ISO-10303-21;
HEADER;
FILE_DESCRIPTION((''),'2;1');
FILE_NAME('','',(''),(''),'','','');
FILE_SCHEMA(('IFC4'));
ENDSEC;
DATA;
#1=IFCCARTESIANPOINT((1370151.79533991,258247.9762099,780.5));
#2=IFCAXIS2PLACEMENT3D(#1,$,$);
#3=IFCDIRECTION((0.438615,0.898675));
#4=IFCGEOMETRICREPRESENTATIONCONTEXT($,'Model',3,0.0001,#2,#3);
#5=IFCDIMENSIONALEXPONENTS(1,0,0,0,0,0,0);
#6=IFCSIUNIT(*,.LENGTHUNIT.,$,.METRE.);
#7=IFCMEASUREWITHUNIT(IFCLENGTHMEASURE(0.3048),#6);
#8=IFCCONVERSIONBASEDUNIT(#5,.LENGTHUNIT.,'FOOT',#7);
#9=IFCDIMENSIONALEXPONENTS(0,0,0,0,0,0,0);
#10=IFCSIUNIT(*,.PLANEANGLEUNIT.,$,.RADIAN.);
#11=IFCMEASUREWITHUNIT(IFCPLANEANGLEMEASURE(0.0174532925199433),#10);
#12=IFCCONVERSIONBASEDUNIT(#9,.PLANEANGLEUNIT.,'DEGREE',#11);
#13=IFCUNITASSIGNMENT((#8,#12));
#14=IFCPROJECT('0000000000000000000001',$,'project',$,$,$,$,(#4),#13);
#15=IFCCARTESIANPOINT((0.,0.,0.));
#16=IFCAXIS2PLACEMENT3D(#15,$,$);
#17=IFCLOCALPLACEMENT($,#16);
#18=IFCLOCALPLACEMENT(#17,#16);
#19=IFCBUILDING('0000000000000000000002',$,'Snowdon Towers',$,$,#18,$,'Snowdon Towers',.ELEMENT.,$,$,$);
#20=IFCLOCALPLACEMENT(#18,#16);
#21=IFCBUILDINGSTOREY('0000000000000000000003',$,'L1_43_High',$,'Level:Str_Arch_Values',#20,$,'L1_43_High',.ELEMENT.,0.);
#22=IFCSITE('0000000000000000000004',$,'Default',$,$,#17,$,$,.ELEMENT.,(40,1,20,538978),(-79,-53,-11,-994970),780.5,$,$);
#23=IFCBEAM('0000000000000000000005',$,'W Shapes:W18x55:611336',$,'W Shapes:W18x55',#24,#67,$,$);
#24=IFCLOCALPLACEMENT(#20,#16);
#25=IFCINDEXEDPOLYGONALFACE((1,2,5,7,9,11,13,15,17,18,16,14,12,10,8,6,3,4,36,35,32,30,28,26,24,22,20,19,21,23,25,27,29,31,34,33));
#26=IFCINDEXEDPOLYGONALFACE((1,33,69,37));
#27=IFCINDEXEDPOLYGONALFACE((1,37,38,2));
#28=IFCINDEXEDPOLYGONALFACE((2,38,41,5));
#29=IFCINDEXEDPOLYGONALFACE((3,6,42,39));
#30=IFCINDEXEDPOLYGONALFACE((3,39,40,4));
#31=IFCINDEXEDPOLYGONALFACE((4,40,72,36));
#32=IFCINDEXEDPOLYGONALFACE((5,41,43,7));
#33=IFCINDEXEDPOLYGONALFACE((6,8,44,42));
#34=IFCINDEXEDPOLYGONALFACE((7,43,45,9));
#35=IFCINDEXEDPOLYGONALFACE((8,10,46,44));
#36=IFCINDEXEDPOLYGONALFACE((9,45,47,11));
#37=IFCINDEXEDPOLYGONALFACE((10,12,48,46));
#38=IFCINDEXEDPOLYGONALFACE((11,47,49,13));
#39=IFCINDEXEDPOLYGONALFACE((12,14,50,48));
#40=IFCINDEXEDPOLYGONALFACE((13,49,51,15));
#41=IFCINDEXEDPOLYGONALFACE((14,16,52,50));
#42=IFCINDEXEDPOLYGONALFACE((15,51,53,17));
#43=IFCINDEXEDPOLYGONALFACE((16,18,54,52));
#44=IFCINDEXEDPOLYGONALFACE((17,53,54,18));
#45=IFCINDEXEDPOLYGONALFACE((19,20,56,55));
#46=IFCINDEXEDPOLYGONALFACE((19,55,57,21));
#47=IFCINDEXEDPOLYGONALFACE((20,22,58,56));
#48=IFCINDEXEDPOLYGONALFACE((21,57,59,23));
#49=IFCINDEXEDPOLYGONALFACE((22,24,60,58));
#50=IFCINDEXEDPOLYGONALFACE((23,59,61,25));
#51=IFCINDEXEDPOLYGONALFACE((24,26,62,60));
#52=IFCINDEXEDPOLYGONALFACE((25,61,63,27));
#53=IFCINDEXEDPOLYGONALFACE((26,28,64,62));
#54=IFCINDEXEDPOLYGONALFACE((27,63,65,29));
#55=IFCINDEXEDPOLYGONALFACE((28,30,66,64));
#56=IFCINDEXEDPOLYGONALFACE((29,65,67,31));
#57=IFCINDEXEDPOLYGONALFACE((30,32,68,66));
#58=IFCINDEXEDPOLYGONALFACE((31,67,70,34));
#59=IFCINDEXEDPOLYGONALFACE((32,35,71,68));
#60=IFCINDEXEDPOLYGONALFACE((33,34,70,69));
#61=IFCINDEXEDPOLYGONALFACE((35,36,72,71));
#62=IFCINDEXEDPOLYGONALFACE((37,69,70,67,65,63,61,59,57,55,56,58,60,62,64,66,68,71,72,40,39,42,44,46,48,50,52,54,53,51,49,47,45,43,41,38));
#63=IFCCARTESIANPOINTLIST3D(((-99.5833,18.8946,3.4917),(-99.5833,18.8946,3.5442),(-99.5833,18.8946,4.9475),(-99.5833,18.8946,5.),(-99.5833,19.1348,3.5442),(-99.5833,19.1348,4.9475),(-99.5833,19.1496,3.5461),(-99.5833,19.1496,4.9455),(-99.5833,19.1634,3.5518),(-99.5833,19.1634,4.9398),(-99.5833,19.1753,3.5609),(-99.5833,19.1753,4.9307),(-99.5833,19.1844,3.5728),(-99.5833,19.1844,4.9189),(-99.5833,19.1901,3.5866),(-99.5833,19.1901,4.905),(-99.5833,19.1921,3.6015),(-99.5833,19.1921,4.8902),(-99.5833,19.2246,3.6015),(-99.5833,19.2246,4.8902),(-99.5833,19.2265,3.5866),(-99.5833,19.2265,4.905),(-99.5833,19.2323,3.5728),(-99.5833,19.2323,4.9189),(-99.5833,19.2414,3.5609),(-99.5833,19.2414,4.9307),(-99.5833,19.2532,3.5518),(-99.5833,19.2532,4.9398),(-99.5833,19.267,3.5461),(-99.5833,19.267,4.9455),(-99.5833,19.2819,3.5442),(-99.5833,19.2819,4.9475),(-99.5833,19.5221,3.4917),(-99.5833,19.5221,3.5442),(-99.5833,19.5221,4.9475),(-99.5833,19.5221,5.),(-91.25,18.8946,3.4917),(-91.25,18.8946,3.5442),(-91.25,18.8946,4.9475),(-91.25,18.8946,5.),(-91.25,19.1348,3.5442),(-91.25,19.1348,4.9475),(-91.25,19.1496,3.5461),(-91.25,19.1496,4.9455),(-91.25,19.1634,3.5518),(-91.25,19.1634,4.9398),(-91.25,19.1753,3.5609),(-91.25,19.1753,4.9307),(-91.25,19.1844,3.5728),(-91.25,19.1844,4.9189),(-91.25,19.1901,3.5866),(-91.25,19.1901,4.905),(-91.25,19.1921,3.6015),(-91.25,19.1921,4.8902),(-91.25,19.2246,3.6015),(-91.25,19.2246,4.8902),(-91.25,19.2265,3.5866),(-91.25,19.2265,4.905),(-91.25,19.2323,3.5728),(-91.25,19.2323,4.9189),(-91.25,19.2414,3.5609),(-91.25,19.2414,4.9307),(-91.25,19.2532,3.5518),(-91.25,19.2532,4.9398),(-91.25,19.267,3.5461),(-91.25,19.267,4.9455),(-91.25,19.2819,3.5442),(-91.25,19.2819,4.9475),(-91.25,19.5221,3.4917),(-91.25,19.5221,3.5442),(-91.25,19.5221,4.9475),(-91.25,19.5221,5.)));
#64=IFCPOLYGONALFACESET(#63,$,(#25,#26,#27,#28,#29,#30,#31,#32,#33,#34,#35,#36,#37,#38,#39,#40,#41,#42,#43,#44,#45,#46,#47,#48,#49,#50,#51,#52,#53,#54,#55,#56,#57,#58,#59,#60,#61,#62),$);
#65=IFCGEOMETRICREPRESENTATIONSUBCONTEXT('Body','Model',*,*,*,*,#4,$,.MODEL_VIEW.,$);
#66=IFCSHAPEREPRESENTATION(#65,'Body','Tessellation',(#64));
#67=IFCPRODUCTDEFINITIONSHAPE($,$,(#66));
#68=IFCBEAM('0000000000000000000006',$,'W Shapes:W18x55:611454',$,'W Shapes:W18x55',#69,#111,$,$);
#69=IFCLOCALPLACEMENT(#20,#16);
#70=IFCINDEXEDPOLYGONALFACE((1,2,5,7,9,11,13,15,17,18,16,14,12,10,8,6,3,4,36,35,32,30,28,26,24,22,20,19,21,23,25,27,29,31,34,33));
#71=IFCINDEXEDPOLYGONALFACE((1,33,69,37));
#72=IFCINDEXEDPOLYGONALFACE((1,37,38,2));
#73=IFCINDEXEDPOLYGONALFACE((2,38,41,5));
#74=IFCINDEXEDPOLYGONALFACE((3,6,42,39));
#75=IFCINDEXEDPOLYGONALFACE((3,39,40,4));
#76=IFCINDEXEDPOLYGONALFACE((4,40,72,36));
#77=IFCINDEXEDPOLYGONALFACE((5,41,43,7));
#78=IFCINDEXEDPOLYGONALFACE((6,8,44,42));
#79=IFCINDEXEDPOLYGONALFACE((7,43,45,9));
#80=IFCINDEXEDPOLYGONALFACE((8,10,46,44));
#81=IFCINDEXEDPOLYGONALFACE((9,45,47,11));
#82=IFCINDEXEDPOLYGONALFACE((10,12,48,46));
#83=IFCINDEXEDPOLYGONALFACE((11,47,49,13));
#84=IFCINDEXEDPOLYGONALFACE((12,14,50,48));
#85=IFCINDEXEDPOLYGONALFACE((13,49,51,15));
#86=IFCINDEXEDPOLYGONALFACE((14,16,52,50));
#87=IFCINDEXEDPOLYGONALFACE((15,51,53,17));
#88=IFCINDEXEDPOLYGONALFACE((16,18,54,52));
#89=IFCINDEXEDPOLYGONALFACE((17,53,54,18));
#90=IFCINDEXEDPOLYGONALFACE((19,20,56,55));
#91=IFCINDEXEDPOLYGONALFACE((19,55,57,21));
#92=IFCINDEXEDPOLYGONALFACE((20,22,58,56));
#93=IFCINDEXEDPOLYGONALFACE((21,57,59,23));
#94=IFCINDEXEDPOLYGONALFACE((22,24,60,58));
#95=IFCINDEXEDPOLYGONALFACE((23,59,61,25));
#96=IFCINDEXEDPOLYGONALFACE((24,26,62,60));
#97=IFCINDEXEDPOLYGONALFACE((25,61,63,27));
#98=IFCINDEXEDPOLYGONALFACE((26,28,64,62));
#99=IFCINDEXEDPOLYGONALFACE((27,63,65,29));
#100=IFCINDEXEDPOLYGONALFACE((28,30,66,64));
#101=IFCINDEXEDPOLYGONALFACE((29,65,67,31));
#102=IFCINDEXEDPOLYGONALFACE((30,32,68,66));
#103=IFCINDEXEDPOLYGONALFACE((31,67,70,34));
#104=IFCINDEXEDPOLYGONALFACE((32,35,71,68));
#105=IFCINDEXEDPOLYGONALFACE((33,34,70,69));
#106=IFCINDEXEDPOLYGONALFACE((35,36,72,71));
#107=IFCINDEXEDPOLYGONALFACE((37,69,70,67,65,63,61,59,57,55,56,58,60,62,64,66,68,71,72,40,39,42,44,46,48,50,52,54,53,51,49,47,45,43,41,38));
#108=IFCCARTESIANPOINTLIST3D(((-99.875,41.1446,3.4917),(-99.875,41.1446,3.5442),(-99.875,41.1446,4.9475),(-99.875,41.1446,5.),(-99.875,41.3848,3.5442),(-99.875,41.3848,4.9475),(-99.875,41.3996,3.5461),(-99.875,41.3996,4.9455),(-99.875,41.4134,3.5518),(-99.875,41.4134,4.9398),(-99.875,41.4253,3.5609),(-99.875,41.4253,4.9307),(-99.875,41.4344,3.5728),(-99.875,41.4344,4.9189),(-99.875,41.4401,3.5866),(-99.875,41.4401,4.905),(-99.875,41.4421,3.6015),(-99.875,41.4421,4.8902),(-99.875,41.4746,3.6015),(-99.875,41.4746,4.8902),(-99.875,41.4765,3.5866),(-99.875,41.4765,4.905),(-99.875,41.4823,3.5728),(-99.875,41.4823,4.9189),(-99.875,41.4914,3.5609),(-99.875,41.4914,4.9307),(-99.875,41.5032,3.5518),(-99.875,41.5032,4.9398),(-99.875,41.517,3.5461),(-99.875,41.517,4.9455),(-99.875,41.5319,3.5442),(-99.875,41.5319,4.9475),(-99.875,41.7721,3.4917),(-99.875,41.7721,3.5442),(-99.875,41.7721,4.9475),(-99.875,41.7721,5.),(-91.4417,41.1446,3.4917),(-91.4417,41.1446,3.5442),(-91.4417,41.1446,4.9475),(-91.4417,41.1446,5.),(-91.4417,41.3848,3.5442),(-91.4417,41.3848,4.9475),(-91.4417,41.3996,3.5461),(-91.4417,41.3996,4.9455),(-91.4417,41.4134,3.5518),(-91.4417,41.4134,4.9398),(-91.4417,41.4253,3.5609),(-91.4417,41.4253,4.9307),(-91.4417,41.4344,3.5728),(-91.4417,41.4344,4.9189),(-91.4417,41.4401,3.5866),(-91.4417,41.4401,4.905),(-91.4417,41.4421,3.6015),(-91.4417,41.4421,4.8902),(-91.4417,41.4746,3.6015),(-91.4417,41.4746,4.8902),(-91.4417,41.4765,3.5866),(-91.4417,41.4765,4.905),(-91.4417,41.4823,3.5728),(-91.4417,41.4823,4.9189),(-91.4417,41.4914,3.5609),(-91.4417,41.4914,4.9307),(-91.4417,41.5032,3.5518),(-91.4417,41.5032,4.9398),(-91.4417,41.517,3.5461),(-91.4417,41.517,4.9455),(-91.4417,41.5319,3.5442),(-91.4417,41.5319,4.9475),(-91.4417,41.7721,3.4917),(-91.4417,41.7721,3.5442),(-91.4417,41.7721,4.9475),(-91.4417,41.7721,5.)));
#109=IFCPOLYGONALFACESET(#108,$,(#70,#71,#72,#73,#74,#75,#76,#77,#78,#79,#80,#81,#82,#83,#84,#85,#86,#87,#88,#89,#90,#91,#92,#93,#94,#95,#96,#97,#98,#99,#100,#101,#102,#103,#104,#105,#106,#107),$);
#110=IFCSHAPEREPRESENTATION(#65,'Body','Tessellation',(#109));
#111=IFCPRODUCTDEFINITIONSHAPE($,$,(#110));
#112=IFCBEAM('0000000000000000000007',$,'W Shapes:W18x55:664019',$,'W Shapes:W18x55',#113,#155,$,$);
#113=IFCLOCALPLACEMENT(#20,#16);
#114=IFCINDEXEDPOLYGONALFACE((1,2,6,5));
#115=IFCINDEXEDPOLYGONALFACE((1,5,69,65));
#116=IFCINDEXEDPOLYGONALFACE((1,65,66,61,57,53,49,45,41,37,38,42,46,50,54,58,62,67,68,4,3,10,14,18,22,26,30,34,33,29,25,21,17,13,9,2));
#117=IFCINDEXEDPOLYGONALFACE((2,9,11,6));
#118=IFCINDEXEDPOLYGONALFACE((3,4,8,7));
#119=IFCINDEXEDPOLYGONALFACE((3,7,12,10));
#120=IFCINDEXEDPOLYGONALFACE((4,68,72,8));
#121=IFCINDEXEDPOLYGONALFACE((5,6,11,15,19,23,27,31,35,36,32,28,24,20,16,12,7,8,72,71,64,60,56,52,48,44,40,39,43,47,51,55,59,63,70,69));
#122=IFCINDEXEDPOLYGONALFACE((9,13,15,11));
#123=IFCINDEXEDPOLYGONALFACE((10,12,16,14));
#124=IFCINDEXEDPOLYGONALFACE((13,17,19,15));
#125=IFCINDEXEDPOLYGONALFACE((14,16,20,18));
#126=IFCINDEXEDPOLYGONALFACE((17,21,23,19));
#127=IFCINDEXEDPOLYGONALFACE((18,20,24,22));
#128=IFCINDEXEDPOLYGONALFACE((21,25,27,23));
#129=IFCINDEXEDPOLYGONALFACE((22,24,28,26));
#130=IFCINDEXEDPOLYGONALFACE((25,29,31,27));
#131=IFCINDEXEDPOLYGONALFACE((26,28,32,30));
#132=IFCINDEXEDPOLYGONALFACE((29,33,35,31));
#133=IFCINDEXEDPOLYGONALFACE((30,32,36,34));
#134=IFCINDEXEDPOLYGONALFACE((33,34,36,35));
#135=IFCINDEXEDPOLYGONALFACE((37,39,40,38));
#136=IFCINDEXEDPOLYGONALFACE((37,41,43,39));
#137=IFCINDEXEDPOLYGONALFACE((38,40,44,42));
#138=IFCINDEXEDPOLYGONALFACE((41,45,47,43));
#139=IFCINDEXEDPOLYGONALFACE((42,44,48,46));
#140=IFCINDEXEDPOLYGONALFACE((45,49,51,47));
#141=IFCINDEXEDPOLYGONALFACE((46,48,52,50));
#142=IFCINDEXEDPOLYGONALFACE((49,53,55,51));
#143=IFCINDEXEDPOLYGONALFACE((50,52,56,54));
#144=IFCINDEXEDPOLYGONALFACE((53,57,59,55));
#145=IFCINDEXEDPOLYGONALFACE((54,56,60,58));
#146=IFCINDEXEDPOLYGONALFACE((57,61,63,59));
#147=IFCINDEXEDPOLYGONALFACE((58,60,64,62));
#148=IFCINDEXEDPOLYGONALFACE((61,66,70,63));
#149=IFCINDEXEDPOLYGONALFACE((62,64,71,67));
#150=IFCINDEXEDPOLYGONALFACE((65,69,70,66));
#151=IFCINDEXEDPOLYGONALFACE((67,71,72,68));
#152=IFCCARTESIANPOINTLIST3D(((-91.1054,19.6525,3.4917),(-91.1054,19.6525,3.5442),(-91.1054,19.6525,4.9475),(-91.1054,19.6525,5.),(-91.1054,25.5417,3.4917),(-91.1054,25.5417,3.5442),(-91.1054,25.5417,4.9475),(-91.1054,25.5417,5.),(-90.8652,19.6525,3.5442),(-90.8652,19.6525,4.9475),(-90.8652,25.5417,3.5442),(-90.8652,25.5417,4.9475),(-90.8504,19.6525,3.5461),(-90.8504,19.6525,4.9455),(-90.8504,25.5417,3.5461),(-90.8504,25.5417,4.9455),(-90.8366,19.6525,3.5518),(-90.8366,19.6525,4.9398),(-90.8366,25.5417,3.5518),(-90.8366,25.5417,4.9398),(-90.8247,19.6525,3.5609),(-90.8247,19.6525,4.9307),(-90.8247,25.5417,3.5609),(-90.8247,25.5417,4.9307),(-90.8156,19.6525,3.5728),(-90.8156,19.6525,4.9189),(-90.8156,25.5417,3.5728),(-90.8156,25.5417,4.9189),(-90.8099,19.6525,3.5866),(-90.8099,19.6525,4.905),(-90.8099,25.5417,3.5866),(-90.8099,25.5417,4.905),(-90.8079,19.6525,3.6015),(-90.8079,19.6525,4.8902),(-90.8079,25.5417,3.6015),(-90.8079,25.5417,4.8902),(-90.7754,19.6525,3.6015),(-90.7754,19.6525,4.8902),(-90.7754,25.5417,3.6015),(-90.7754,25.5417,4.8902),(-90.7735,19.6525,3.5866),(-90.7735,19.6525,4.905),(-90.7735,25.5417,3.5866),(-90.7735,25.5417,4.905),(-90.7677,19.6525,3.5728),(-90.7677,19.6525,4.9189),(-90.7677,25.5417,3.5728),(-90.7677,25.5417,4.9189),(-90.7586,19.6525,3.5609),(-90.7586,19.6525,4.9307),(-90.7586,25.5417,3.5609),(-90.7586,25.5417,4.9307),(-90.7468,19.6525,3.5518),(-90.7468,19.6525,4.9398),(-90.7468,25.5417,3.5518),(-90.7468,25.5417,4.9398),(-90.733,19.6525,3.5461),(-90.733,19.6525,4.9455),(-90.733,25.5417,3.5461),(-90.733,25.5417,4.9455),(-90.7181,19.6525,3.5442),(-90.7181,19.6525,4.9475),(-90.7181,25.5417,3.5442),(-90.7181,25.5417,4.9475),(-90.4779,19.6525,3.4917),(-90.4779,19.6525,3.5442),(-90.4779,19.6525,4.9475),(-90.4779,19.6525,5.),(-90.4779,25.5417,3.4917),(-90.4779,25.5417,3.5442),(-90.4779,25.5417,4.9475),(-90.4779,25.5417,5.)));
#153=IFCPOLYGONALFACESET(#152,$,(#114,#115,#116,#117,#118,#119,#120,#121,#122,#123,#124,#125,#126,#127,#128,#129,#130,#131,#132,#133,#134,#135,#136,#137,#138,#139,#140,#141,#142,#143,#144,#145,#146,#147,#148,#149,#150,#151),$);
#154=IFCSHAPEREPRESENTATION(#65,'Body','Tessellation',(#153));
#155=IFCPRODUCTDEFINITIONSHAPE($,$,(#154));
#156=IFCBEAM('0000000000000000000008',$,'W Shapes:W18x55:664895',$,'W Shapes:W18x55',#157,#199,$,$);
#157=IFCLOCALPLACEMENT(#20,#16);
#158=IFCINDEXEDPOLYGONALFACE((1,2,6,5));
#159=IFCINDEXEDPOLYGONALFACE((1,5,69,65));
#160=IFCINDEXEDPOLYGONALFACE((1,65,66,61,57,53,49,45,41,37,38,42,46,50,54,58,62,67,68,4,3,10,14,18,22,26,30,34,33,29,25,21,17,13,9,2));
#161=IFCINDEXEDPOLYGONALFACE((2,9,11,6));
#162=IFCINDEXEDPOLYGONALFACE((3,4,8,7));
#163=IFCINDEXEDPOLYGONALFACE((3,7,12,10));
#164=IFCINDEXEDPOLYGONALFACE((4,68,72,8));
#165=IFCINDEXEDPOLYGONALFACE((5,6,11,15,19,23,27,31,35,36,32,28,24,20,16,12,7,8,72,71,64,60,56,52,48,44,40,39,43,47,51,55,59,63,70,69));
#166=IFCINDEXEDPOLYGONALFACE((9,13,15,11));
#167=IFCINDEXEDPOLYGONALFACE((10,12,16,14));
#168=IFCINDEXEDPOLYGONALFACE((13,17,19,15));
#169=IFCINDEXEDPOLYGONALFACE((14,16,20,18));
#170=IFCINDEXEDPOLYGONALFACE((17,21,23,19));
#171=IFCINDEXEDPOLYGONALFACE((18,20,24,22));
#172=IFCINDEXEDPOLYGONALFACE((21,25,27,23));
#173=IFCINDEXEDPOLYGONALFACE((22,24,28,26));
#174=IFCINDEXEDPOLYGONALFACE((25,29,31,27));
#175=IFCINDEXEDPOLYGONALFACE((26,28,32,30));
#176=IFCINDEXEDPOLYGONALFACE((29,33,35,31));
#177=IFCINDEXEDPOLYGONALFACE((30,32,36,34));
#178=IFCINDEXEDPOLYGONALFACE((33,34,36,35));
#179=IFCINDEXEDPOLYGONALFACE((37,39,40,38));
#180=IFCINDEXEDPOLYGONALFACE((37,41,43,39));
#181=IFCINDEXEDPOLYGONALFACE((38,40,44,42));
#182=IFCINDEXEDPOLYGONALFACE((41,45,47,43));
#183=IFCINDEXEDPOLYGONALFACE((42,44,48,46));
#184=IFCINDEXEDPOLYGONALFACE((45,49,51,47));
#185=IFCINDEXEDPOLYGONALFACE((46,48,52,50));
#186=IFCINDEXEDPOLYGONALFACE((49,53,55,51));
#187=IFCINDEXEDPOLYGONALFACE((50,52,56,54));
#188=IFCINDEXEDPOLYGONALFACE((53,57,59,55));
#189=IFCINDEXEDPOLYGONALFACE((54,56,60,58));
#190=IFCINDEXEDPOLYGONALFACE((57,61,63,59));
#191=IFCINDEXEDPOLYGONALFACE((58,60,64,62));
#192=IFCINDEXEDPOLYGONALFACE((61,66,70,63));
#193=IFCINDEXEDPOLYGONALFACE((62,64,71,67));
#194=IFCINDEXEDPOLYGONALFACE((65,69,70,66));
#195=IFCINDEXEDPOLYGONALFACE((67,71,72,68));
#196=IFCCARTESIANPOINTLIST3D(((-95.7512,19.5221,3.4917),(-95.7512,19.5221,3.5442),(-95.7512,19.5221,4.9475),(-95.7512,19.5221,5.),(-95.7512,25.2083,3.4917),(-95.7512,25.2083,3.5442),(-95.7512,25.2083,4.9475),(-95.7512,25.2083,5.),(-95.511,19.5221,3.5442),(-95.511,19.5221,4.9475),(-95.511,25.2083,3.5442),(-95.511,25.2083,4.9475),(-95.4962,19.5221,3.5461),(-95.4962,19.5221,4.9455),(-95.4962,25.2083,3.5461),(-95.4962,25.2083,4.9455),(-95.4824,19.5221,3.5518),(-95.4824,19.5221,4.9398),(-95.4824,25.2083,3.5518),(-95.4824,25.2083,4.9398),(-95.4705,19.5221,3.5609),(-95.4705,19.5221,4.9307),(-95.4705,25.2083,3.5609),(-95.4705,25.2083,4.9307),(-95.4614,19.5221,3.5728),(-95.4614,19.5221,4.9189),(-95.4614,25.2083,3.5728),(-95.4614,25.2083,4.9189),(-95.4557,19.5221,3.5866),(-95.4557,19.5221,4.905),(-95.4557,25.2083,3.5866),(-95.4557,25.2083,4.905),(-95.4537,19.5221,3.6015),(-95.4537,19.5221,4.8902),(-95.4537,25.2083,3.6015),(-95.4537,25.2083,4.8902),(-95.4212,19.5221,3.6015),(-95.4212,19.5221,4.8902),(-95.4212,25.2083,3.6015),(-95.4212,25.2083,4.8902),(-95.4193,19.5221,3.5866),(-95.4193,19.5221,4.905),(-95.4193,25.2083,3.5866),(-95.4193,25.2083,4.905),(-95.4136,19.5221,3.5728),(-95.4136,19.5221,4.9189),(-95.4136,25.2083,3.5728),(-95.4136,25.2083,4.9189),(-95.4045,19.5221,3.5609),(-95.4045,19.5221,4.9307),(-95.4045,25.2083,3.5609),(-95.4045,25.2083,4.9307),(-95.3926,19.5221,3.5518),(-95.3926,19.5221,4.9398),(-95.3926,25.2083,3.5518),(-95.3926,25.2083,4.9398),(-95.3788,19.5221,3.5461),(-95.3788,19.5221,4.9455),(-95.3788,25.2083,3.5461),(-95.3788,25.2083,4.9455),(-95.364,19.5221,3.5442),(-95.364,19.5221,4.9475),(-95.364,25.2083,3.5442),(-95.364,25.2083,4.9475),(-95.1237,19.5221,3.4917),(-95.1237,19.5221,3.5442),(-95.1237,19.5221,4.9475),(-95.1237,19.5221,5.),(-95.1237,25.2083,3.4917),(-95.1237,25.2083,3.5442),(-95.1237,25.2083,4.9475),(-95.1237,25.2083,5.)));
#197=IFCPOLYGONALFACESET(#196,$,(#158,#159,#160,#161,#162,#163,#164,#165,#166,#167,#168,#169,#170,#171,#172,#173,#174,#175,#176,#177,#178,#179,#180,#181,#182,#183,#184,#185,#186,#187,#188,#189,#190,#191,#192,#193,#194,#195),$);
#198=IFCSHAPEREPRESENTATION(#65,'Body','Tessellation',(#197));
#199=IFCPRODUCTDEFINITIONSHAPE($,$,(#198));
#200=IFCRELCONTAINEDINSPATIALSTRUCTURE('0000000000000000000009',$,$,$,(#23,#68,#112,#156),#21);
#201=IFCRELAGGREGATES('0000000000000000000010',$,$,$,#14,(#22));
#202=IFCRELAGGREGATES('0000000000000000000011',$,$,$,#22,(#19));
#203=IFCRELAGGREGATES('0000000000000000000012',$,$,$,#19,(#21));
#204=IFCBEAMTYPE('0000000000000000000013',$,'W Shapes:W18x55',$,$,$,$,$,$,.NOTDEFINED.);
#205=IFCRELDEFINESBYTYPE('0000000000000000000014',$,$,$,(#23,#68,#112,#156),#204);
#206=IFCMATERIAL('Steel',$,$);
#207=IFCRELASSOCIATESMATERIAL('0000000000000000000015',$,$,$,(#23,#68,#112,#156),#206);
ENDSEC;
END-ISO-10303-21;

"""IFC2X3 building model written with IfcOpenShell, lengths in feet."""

from ifc_helpers import new_model, entity, si_unit, converted_unit, direction, frame, frame_2d, origin, place, context, subcontext, project, spatial, i_section, extrude, material, type_object, element, save


model = new_model("IFC2X3")

# Units and contexts
model_context = context("Model", 3, precision=0.0001, world=frame((1370151.79533991, 258247.9762099, 780.5)), true_north=direction((0.438615, 0.898675)))
body_context = subcontext(model_context, "Body", "Model", "MODEL_VIEW")
ifc_project = project(units=[converted_unit("LENGTHUNIT", "FOOT", entity("IfcLengthMeasure", 0.3048), si_unit("LENGTHUNIT", "METRE"), dimensions=[1, 0, 0, 0, 0, 0, 0]), converted_unit("PLANEANGLEUNIT", "DEGREE", entity("IfcPlaneAngleMeasure", 0.0174532925199433), si_unit("PLANEANGLEUNIT", "RADIAN"), dimensions=[0, 0, 0, 0, 0, 0, 0])], contexts=[model_context])

# Site, building, storey
site_placement = place(None, origin())
site = spatial("IfcSite", under=ifc_project, at=site_placement, Name="Default", CompositionType="ELEMENT", RefLatitude=(40, 1, 20, 538978), RefLongitude=(-79, -53, -11, -994970), RefElevation=780.5)
building_placement = place(site_placement, origin())
building = spatial("IfcBuilding", under=site, at=building_placement, Name="Snowdon Towers", LongName="Snowdon Towers", CompositionType="ELEMENT")
storey_placement = place(building_placement, origin())
storey = spatial("IfcBuildingStorey", under=building, at=storey_placement, Name="L1_43_High", ObjectType="Level:Str_Arch_Values", LongName="L1_43_High", CompositionType="ELEMENT", Elevation=0.0)

# Beams
ifc_material_1 = material(Name="Steel")
beam_type = type_object("IfcBeamType", Name="W Shapes:W18x55", PredefinedType="NOTDEFINED")
beam_1_placement = place(storey_placement, frame((-100.125, 19.2083, 5.0)))
element("IfcBeam", 1, at=beam_1_placement, inside=storey, type_object=beam_type, material=ifc_material_1, Name="W Shapes:W18x55:611336", ObjectType="W Shapes:W18x55", context=body_context, shape_type="SweptSolid", body=[
    extrude(i_section(OverallWidth=0.6275, OverallDepth=1.5083, WebThickness=0.0325, FlangeThickness=0.0525, FilletRadius=0.0573, at=frame_2d((0.0, 0.0), x_axis=(0.0, 1.0))), frame((0.5417, 0.0, -0.7542), z_axis=(1.0, 0.0, 0.0), x_axis=(0.0, 0.0, -1.0)), (0.0, 0.0, 1.0), 8.3333),
])
beam_2_placement = place(storey_placement, frame((-100.125, 41.4583, 5.0)))
element("IfcBeam", 2, at=beam_2_placement, inside=storey, type_object=beam_type, material=ifc_material_1, Name="W Shapes:W18x55:611454", ObjectType="W Shapes:W18x55", context=body_context, shape_type="SweptSolid", body=[
    extrude(i_section(OverallWidth=0.6275, OverallDepth=1.5083, WebThickness=0.0325, FlangeThickness=0.0525, FilletRadius=0.0573, at=frame_2d((0.0, 0.0), x_axis=(0.0, 1.0))), frame((0.25, 0.0, -0.7542), z_axis=(1.0, 0.0, 0.0), x_axis=(0.0, 0.0, -1.0)), (0.0, 0.0, 1.0), 8.4333),
])
beam_3_placement = place(storey_placement, frame((-90.7917, 19.1942, 5.0), z_axis=(0.0, 0.0, 1.0), x_axis=(0.0, 1.0, 0.0)))
element("IfcBeam", 3, at=beam_3_placement, inside=storey, type_object=beam_type, material=ifc_material_1, Name="W Shapes:W18x55:664019", ObjectType="W Shapes:W18x55", context=body_context, shape_type="SweptSolid", body=[
    extrude(i_section(OverallWidth=0.6275, OverallDepth=1.5083, WebThickness=0.0325, FlangeThickness=0.0525, FilletRadius=0.0573, at=frame_2d((0.0, 0.0), x_axis=(0.0, 1.0))), frame((0.4583, 0.0, -0.7542), z_axis=(1.0, 0.0, 0.0), x_axis=(0.0, 0.0, -1.0)), (0.0, 0.0, 1.0), 5.8892),
])
beam_4_placement = place(storey_placement, frame((-95.4375, 19.2083, 5.0), z_axis=(0.0, 0.0, 1.0), x_axis=(0.0, 1.0, 0.0)))
element("IfcBeam", 4, at=beam_4_placement, inside=storey, type_object=beam_type, material=ifc_material_1, Name="W Shapes:W18x55:664895", ObjectType="W Shapes:W18x55", context=body_context, shape_type="SweptSolid", body=[
    extrude(i_section(OverallWidth=0.6275, OverallDepth=1.5083, WebThickness=0.0325, FlangeThickness=0.0525, FilletRadius=0.0573, at=frame_2d((0.0, 0.0), x_axis=(0.0, 1.0))), frame((0.3137, 0.0, -0.7542), z_axis=(1.0, 0.0, 0.0), x_axis=(0.0, 0.0, -1.0)), (0.0, 0.0, 1.0), 5.6862),
])

save(model, "model.ifc")
